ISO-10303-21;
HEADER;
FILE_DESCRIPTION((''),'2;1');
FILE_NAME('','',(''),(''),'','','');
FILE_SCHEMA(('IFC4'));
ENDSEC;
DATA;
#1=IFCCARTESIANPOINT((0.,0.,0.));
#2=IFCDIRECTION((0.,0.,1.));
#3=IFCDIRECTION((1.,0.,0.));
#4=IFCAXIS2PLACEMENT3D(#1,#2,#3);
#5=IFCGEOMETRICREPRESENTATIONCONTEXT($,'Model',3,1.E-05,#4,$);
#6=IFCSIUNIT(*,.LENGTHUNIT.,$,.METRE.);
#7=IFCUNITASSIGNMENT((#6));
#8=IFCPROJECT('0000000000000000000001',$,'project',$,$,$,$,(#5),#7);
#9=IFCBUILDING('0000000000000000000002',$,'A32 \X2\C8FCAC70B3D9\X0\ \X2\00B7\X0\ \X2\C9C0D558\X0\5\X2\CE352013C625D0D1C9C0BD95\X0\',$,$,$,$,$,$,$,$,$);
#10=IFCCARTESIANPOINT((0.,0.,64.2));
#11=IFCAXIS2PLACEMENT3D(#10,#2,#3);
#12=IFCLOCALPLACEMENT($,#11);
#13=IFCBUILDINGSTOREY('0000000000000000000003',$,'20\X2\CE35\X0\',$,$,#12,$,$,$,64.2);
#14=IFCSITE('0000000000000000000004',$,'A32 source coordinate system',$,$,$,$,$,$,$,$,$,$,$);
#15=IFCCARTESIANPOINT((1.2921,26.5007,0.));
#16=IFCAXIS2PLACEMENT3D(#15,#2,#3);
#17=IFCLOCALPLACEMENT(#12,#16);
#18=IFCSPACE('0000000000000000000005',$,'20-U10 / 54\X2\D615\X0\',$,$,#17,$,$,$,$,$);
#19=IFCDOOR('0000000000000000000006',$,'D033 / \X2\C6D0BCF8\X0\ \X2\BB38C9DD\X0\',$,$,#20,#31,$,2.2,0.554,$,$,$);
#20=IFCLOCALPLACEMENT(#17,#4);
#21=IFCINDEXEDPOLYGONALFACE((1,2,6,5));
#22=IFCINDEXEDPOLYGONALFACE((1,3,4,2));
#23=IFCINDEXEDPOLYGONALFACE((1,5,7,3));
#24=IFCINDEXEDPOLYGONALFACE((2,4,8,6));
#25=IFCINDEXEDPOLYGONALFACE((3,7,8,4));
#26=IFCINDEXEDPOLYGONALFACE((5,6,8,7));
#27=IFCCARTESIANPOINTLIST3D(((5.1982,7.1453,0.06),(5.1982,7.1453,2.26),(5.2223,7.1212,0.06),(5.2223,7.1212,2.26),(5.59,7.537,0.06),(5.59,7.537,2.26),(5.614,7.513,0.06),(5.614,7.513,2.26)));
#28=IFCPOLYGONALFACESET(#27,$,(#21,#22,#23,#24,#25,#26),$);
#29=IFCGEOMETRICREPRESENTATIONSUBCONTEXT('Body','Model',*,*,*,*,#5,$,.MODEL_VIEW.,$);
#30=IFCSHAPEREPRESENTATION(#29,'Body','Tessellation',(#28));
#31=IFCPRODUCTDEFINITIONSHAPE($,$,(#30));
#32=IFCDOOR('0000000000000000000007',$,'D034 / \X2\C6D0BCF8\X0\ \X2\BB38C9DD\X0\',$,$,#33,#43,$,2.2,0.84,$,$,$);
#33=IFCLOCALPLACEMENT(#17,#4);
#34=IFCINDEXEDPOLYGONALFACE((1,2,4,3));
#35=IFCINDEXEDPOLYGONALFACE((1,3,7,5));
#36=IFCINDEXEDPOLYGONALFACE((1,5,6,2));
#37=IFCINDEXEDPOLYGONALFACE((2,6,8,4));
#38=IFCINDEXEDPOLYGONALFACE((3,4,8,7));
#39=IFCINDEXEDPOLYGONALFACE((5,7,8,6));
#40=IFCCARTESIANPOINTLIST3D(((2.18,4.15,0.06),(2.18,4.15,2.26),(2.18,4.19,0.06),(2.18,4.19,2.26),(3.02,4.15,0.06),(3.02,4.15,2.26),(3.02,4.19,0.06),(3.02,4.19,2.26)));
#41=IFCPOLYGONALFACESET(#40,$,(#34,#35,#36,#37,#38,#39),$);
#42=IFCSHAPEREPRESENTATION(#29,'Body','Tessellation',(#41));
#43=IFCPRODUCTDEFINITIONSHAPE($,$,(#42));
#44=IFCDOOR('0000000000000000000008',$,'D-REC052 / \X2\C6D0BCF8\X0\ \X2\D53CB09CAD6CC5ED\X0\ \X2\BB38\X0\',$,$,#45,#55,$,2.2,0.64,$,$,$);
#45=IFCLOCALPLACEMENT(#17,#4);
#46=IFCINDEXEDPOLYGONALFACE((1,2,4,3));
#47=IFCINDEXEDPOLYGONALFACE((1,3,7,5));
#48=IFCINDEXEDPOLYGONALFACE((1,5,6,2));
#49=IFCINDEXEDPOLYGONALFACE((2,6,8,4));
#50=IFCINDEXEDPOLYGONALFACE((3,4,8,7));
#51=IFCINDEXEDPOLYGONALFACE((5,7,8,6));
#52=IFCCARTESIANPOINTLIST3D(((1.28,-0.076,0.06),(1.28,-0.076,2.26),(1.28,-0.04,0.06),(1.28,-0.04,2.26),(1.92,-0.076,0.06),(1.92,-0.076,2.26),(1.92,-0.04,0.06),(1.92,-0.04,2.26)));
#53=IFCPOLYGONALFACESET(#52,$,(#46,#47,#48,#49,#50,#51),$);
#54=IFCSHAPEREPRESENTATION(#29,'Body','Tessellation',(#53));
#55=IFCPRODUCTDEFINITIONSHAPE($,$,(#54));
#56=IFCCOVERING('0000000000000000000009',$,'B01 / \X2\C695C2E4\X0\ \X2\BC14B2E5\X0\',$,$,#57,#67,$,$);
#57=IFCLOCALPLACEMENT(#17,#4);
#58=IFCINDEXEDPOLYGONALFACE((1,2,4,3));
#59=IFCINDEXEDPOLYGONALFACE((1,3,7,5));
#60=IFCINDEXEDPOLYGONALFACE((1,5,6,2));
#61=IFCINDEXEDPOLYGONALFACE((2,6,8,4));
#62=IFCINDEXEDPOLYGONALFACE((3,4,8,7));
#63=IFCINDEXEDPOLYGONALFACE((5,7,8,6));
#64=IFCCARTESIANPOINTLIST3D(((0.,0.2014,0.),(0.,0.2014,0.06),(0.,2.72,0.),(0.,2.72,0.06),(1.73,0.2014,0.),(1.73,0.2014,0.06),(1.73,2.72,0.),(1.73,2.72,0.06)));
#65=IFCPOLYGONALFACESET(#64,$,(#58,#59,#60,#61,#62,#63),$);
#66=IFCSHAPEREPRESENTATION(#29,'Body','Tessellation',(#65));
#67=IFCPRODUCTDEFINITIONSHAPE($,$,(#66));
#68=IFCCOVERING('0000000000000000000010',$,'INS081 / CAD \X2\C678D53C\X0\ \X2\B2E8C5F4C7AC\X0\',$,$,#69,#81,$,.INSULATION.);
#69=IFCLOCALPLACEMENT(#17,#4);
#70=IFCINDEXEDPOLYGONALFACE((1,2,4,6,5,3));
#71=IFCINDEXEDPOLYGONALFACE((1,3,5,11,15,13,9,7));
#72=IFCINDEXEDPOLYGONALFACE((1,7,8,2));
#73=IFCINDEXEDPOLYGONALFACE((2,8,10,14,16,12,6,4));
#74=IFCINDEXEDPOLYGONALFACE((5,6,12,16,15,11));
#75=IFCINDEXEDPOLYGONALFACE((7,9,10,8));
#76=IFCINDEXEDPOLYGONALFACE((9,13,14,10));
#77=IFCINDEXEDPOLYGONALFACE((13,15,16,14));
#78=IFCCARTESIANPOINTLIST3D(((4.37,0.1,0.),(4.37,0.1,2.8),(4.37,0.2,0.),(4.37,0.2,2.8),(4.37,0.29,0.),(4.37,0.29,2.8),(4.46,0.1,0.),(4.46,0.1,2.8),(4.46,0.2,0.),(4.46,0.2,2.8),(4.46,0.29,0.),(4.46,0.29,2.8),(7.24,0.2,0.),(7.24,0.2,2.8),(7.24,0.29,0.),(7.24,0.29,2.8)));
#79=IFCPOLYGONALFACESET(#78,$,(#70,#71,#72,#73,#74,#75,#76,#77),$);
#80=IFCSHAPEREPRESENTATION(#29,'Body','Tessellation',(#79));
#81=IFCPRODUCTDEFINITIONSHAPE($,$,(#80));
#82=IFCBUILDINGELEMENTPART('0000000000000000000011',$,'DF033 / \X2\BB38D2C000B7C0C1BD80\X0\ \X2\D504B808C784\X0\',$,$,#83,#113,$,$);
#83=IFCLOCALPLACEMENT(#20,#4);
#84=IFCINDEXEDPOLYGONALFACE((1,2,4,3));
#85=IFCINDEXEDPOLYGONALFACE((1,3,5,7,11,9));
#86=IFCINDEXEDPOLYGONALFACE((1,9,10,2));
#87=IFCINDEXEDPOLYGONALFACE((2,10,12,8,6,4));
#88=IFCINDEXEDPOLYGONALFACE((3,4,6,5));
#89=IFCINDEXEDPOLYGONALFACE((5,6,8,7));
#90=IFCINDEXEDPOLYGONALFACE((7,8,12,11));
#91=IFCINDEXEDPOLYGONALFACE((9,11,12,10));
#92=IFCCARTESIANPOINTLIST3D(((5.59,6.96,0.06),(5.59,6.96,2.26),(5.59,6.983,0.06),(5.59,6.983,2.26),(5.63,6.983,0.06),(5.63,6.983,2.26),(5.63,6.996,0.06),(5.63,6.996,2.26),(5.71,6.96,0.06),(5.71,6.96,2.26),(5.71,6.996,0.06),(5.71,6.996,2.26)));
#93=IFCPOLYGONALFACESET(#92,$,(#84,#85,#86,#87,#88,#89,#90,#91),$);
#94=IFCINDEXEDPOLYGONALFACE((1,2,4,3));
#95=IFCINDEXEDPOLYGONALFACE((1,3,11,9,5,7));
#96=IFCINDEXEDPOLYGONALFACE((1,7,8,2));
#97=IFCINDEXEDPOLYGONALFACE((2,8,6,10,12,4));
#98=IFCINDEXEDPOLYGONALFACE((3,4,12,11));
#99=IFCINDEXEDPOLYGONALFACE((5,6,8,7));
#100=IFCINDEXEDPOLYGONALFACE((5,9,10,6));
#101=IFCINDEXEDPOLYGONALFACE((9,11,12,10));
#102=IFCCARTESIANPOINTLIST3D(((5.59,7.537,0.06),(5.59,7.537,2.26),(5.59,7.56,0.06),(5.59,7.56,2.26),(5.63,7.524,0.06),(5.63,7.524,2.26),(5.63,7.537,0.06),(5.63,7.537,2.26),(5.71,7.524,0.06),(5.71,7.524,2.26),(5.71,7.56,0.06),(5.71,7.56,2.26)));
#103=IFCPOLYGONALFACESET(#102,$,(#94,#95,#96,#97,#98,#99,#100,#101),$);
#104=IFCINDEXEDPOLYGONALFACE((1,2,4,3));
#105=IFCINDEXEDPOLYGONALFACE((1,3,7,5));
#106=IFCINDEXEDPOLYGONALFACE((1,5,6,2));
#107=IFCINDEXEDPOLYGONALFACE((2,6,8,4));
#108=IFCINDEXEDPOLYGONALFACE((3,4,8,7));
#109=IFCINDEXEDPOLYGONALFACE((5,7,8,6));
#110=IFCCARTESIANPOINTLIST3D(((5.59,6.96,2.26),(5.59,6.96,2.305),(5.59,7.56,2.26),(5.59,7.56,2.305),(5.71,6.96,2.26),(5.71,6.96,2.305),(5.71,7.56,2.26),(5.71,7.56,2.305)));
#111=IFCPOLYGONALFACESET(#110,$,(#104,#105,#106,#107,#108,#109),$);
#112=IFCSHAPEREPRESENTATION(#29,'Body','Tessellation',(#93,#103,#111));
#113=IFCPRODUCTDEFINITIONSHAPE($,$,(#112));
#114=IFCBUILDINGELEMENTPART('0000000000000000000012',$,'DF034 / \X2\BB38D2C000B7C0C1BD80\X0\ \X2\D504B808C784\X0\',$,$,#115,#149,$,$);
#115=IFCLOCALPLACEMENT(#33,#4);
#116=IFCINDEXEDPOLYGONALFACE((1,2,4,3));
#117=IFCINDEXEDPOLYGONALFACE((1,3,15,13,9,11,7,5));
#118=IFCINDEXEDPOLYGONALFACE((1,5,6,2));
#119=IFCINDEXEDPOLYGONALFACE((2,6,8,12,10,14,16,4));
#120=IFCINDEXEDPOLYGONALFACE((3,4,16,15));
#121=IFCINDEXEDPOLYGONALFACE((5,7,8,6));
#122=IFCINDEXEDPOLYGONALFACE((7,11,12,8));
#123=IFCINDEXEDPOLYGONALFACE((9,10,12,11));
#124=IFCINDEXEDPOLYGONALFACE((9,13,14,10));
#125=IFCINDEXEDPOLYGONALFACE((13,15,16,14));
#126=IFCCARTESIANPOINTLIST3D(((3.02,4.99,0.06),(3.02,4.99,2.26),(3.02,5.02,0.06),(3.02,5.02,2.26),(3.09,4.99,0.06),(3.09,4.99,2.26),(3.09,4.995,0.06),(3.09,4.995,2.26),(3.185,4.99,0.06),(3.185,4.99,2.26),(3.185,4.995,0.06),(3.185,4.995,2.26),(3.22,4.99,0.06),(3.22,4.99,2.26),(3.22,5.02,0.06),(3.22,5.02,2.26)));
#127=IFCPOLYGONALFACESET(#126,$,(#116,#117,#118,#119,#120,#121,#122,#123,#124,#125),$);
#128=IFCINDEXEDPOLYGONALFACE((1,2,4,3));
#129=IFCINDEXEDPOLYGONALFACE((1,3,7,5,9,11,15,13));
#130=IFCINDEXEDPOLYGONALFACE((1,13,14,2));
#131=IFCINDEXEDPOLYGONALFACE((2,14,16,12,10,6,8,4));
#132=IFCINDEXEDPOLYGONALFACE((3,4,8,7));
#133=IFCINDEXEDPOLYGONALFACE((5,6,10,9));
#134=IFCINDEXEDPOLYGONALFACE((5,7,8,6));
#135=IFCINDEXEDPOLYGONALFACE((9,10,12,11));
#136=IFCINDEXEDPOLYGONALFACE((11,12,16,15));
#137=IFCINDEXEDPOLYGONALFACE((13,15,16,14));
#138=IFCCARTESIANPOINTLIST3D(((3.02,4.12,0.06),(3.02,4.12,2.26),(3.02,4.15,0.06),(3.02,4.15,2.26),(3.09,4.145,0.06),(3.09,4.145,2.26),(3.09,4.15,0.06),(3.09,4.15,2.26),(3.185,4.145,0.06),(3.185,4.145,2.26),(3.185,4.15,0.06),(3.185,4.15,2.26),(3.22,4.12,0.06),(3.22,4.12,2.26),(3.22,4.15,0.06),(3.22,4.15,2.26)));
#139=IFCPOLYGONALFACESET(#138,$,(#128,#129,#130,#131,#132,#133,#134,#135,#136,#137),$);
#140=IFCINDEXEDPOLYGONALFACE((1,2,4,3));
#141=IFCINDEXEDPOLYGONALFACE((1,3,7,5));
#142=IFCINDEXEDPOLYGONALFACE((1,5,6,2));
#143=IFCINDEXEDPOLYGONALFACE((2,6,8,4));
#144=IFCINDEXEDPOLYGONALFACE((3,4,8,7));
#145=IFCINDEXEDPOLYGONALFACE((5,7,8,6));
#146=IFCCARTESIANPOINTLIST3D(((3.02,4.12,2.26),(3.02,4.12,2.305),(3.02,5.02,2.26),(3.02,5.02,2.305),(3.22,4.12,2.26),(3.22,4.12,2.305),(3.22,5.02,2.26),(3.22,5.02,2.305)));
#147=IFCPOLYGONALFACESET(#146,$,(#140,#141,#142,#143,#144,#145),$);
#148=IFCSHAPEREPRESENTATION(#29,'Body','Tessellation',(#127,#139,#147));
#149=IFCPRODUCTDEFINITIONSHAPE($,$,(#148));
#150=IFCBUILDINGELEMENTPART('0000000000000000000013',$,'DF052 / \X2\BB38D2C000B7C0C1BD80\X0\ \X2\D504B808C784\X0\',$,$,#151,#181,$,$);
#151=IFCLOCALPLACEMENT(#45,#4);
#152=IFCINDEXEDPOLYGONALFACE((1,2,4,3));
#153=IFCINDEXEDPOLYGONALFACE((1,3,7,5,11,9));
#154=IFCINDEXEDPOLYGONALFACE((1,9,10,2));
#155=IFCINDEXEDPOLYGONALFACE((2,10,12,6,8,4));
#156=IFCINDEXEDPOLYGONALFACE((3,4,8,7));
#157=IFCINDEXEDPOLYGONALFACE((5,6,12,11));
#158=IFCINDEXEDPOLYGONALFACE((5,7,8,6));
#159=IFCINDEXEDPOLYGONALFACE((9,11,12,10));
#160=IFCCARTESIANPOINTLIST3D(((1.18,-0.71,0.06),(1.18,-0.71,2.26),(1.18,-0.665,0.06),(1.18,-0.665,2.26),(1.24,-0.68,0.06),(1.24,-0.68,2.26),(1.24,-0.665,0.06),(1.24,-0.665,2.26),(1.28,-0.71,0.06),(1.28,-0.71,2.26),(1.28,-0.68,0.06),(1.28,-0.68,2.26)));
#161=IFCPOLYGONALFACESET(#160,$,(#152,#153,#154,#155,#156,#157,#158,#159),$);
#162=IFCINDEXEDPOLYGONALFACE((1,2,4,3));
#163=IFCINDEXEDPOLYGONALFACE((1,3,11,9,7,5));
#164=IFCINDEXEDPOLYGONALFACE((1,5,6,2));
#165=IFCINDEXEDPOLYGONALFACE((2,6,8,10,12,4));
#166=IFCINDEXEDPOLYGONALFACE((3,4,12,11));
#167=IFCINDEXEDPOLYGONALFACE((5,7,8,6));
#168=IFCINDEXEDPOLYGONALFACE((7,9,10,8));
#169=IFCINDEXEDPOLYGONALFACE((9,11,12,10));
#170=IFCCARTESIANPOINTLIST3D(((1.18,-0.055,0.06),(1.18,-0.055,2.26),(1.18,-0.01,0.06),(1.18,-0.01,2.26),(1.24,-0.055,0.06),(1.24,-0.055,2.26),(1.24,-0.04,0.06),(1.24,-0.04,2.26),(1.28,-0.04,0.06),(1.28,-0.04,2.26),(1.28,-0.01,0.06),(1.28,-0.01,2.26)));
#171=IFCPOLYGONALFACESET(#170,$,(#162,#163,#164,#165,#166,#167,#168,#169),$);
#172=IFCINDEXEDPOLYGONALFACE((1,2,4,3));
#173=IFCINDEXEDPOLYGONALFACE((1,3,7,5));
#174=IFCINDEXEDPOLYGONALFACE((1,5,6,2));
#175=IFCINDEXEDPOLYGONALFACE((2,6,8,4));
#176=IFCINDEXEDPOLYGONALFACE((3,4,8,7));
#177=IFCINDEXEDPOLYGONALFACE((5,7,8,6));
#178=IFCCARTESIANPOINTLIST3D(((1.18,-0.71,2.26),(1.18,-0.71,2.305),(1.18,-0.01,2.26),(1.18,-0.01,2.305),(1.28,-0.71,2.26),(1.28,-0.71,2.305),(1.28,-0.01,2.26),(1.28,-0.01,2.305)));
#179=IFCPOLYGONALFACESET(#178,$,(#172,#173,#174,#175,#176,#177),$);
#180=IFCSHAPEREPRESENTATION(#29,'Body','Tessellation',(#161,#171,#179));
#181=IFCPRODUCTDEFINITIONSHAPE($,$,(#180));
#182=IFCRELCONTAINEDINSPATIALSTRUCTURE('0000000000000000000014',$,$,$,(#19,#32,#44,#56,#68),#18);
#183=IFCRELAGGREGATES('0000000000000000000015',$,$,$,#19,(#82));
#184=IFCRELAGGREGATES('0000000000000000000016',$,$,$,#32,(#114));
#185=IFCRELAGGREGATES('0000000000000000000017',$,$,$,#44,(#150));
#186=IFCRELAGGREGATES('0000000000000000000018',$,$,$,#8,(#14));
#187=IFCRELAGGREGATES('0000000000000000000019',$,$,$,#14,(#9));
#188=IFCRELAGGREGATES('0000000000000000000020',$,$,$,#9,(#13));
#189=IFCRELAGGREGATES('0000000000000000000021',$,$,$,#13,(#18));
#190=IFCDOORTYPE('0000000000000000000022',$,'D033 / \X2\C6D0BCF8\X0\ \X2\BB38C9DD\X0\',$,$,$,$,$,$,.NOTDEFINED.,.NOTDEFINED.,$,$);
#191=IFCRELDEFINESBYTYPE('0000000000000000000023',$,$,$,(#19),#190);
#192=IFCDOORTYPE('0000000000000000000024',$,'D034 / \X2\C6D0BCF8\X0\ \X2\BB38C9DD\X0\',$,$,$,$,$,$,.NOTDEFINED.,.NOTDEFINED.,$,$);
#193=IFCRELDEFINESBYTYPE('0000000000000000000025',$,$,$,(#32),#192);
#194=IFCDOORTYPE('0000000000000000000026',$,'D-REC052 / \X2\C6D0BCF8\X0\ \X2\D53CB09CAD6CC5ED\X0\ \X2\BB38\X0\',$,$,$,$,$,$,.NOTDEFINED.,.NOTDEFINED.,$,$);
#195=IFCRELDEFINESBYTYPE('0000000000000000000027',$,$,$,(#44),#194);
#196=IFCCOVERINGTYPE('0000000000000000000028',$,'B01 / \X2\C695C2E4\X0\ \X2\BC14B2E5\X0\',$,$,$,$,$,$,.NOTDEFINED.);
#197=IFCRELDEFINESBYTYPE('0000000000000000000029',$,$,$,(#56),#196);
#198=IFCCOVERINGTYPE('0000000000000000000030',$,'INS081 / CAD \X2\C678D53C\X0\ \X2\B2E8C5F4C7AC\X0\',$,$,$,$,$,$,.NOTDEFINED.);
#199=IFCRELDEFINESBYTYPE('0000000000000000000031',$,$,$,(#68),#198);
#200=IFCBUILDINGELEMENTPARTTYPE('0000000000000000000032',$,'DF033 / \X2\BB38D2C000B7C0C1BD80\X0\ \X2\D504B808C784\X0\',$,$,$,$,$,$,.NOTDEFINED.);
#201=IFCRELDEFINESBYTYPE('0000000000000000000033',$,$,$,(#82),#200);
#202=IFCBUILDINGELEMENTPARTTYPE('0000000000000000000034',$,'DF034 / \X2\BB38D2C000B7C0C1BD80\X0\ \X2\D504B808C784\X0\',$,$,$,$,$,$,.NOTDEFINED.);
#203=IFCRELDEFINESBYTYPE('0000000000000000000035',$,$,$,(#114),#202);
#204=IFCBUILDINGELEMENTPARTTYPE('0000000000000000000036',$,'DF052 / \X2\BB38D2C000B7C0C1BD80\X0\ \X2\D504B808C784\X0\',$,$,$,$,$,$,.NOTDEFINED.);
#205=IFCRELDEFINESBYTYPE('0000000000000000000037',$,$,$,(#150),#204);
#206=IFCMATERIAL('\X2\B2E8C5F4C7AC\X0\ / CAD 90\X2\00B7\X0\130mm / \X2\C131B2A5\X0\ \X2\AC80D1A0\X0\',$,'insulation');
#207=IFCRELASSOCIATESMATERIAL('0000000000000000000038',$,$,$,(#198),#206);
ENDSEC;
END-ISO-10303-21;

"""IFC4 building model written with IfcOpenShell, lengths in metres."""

from ifc_helpers import new_model, si_unit, frame, origin, origin_with_axes, place, context, subcontext, project, spatial, polyline, outline, extrude, source, transform, mapped, material, type_object, type_shapes, element, aggregate, save


model = new_model("IFC4")

# Units and contexts
model_context = context("Model", 3, precision=1e-05, world=origin_with_axes())
body_context = subcontext(model_context, "Body", "Model", "MODEL_VIEW")
ifc_project = project(units=[si_unit("LENGTHUNIT", "METRE")], contexts=[model_context])

# Site, building, storey, space
storey_placement = place(None, frame((0.0, 0.0, 64.2), z_axis=(0.0, 0.0, 1.0), x_axis=(1.0, 0.0, 0.0)))
space_placement = place(storey_placement, frame((1.2921, 26.5007, 0.0), z_axis=(0.0, 0.0, 1.0), x_axis=(1.0, 0.0, 0.0)))
site = spatial("IfcSite", under=ifc_project, Name="A32 source coordinate system")
building = spatial("IfcBuilding", under=site, Name="A32 주거동 · 지하5층–옥탑지붕")
storey = spatial("IfcBuildingStorey", under=building, at=storey_placement, Name="20층", Elevation=64.2)
space = spatial("IfcSpace", under=storey, at=space_placement, Name="20-U10 / 54형")

# Doors
door_type_1 = type_object("IfcDoorType", Name="D033 / 원본 문짝", OperationType="NOTDEFINED", PredefinedType="NOTDEFINED")
shared_shape_1 = source(origin(), body_context, "Body", "SweptSolid", [
    extrude(outline(polyline([(5.2223, 7.1212), (5.1982, 7.1453), (5.59, 7.537), (5.614, 7.513), (5.2223, 7.1212)])), frame((0.0, 0.0, 0.06)), (0.0, 0.0, 1.0), 2.2),
])
type_shapes(door_type_1, [shared_shape_1])
door_1_placement = place(space_placement, origin_with_axes())
door_1 = element("IfcDoor", 1, at=door_1_placement, inside=space, type_object=door_type_1, Name="D033 / 원본 문짝", OverallHeight=2.2, OverallWidth=0.554, context=body_context, shape_type="MappedRepresentation", body=[
    mapped(shared_shape_1, transform((0.0, 0.0, 0.0), scale=1.0)),
])
door_type_2 = type_object("IfcDoorType", Name="D034 / 원본 문짝", OperationType="NOTDEFINED", PredefinedType="NOTDEFINED")
shared_shape_2 = source(origin(), body_context, "Body", "SweptSolid", [
    extrude(outline(polyline([(3.02, 4.15), (2.18, 4.15), (2.18, 4.19), (3.02, 4.19), (3.02, 4.15)])), frame((0.0, 0.0, 0.06)), (0.0, 0.0, 1.0), 2.2),
])
type_shapes(door_type_2, [shared_shape_2])
door_2_placement = place(space_placement, origin_with_axes())
door_2 = element("IfcDoor", 2, at=door_2_placement, inside=space, type_object=door_type_2, Name="D034 / 원본 문짝", OverallHeight=2.2, OverallWidth=0.84, context=body_context, shape_type="MappedRepresentation", body=[
    mapped(shared_shape_2, transform((0.0, 0.0, 0.0), scale=1.0)),
])
door_type_3 = type_object("IfcDoorType", Name="D-REC052 / 원본 피난구역 문", OperationType="NOTDEFINED", PredefinedType="NOTDEFINED")
shared_shape_3 = source(origin(), body_context, "Body", "SweptSolid", [
    extrude(outline(polyline([(1.92, -0.076), (1.28, -0.076), (1.28, -0.04), (1.92, -0.04), (1.92, -0.076)])), frame((0.0, 0.0, 0.06)), (0.0, 0.0, 1.0), 2.2),
])
type_shapes(door_type_3, [shared_shape_3])
door_3_placement = place(space_placement, origin_with_axes())
door_3 = element("IfcDoor", 3, at=door_3_placement, inside=space, type_object=door_type_3, Name="D-REC052 / 원본 피난구역 문", OverallHeight=2.2, OverallWidth=0.64, context=body_context, shape_type="MappedRepresentation", body=[
    mapped(shared_shape_3, transform((0.0, 0.0, 0.0), scale=1.0)),
])

# Coverings
covering_type_1 = type_object("IfcCoveringType", Name="B01 / 욕실 바닥", PredefinedType="NOTDEFINED")
shared_shape_4 = source(origin(), body_context, "Body", "SweptSolid", [
    extrude(outline(polyline([(0.0, 0.2014), (0.0, 2.72), (1.73, 2.72), (1.73, 0.2014), (0.0, 0.2014)])), origin(), (0.0, 0.0, 1.0), 0.06),
])
type_shapes(covering_type_1, [shared_shape_4])
covering_1_placement = place(space_placement, origin_with_axes())
element("IfcCovering", 4, at=covering_1_placement, inside=space, type_object=covering_type_1, Name="B01 / 욕실 바닥", context=body_context, shape_type="MappedRepresentation", body=[
    mapped(shared_shape_4, transform((0.0, 0.0, 0.0), scale=1.0)),
])
ifc_material = material(Name="단열재 / CAD 90·130mm / 성능 검토", Category="insulation")
covering_type_2 = type_object("IfcCoveringType", Name="INS081 / CAD 외피 단열재", PredefinedType="NOTDEFINED", material=ifc_material)
shared_shape_5 = source(origin(), body_context, "Body", "SweptSolid", [
    extrude(outline(polyline([(4.37, 0.2), (4.37, 0.29), (4.46, 0.29), (7.24, 0.29), (7.24, 0.2), (4.46, 0.2), (4.46, 0.1), (4.37, 0.1), (4.37, 0.2)])), origin(), (0.0, 0.0, 1.0), 2.8),
])
type_shapes(covering_type_2, [shared_shape_5])
covering_2_placement = place(space_placement, origin_with_axes())
element("IfcCovering", 5, at=covering_2_placement, inside=space, type_object=covering_type_2, Name="INS081 / CAD 외피 단열재", PredefinedType="INSULATION", context=body_context, shape_type="MappedRepresentation", body=[
    mapped(shared_shape_5, transform((0.0, 0.0, 0.0), scale=1.0)),
])

# Building element parts
building_element_part_type_1 = type_object("IfcBuildingElementPartType", Name="DF033 / 문틀·상부 프레임", PredefinedType="NOTDEFINED")
shared_shape_6 = source(origin(), body_context, "Body", "SweptSolid", [
    extrude(outline(polyline([(5.59, 6.96), (5.59, 6.983), (5.63, 6.983), (5.63, 6.996), (5.71, 6.996), (5.71, 6.96), (5.59, 6.96)])), frame((0.0, 0.0, 0.06)), (0.0, 0.0, 1.0), 2.2),
    extrude(outline(polyline([(5.71, 7.524), (5.63, 7.524), (5.63, 7.537), (5.59, 7.537), (5.59, 7.56), (5.71, 7.56), (5.71, 7.524)])), frame((0.0, 0.0, 0.06)), (0.0, 0.0, 1.0), 2.2),
    extrude(outline(polyline([(5.59, 6.96), (5.59, 7.56), (5.71, 7.56), (5.71, 6.96), (5.59, 6.96)])), frame((0.0, 0.0, 2.26)), (0.0, 0.0, 1.0), 0.045),
])
type_shapes(building_element_part_type_1, [shared_shape_6])
building_element_part_1_placement = place(door_1_placement, origin_with_axes())
building_element_part_1 = element("IfcBuildingElementPart", 6, at=building_element_part_1_placement, type_object=building_element_part_type_1, Name="DF033 / 문틀·상부 프레임", context=body_context, shape_type="MappedRepresentation", body=[
    mapped(shared_shape_6, transform((0.0, 0.0, 0.0), scale=1.0)),
])
aggregate(door_1, [building_element_part_1])
building_element_part_type_2 = type_object("IfcBuildingElementPartType", Name="DF034 / 문틀·상부 프레임", PredefinedType="NOTDEFINED")
shared_shape_7 = source(origin(), body_context, "Body", "SweptSolid", [
    extrude(outline(polyline([(3.22, 5.02), (3.22, 4.99), (3.185, 4.99), (3.185, 4.995), (3.09, 4.995), (3.09, 4.99), (3.02, 4.99), (3.02, 5.02), (3.22, 5.02)])), frame((0.0, 0.0, 0.06)), (0.0, 0.0, 1.0), 2.2),
    extrude(outline(polyline([(3.02, 4.15), (3.09, 4.15), (3.09, 4.145), (3.185, 4.145), (3.185, 4.15), (3.22, 4.15), (3.22, 4.12), (3.02, 4.12), (3.02, 4.15)])), frame((0.0, 0.0, 0.06)), (0.0, 0.0, 1.0), 2.2),
    extrude(outline(polyline([(3.02, 4.12), (3.02, 5.02), (3.22, 5.02), (3.22, 4.12), (3.02, 4.12)])), frame((0.0, 0.0, 2.26)), (0.0, 0.0, 1.0), 0.045),
])
type_shapes(building_element_part_type_2, [shared_shape_7])
building_element_part_2_placement = place(door_2_placement, origin_with_axes())
building_element_part_2 = element("IfcBuildingElementPart", 7, at=building_element_part_2_placement, type_object=building_element_part_type_2, Name="DF034 / 문틀·상부 프레임", context=body_context, shape_type="MappedRepresentation", body=[
    mapped(shared_shape_7, transform((0.0, 0.0, 0.0), scale=1.0)),
])
aggregate(door_2, [building_element_part_2])
building_element_part_type_3 = type_object("IfcBuildingElementPartType", Name="DF052 / 문틀·상부 프레임", PredefinedType="NOTDEFINED")
shared_shape_8 = source(origin(), body_context, "Body", "SweptSolid", [
    extrude(outline(polyline([(1.18, -0.71), (1.18, -0.665), (1.24, -0.665), (1.24, -0.68), (1.28, -0.68), (1.28, -0.71), (1.18, -0.71)])), frame((0.0, 0.0, 0.06)), (0.0, 0.0, 1.0), 2.2),
    extrude(outline(polyline([(1.28, -0.04), (1.24, -0.04), (1.24, -0.055), (1.18, -0.055), (1.18, -0.01), (1.28, -0.01), (1.28, -0.04)])), frame((0.0, 0.0, 0.06)), (0.0, 0.0, 1.0), 2.2),
    extrude(outline(polyline([(1.18, -0.71), (1.18, -0.01), (1.28, -0.01), (1.28, -0.71), (1.18, -0.71)])), frame((0.0, 0.0, 2.26)), (0.0, 0.0, 1.0), 0.045),
])
type_shapes(building_element_part_type_3, [shared_shape_8])
building_element_part_3_placement = place(door_3_placement, origin_with_axes())
building_element_part_3 = element("IfcBuildingElementPart", 8, at=building_element_part_3_placement, type_object=building_element_part_type_3, Name="DF052 / 문틀·상부 프레임", context=body_context, shape_type="MappedRepresentation", body=[
    mapped(shared_shape_8, transform((0.0, 0.0, 0.0), scale=1.0)),
])
aggregate(door_3, [building_element_part_3])

save(model, "model.ifc")
